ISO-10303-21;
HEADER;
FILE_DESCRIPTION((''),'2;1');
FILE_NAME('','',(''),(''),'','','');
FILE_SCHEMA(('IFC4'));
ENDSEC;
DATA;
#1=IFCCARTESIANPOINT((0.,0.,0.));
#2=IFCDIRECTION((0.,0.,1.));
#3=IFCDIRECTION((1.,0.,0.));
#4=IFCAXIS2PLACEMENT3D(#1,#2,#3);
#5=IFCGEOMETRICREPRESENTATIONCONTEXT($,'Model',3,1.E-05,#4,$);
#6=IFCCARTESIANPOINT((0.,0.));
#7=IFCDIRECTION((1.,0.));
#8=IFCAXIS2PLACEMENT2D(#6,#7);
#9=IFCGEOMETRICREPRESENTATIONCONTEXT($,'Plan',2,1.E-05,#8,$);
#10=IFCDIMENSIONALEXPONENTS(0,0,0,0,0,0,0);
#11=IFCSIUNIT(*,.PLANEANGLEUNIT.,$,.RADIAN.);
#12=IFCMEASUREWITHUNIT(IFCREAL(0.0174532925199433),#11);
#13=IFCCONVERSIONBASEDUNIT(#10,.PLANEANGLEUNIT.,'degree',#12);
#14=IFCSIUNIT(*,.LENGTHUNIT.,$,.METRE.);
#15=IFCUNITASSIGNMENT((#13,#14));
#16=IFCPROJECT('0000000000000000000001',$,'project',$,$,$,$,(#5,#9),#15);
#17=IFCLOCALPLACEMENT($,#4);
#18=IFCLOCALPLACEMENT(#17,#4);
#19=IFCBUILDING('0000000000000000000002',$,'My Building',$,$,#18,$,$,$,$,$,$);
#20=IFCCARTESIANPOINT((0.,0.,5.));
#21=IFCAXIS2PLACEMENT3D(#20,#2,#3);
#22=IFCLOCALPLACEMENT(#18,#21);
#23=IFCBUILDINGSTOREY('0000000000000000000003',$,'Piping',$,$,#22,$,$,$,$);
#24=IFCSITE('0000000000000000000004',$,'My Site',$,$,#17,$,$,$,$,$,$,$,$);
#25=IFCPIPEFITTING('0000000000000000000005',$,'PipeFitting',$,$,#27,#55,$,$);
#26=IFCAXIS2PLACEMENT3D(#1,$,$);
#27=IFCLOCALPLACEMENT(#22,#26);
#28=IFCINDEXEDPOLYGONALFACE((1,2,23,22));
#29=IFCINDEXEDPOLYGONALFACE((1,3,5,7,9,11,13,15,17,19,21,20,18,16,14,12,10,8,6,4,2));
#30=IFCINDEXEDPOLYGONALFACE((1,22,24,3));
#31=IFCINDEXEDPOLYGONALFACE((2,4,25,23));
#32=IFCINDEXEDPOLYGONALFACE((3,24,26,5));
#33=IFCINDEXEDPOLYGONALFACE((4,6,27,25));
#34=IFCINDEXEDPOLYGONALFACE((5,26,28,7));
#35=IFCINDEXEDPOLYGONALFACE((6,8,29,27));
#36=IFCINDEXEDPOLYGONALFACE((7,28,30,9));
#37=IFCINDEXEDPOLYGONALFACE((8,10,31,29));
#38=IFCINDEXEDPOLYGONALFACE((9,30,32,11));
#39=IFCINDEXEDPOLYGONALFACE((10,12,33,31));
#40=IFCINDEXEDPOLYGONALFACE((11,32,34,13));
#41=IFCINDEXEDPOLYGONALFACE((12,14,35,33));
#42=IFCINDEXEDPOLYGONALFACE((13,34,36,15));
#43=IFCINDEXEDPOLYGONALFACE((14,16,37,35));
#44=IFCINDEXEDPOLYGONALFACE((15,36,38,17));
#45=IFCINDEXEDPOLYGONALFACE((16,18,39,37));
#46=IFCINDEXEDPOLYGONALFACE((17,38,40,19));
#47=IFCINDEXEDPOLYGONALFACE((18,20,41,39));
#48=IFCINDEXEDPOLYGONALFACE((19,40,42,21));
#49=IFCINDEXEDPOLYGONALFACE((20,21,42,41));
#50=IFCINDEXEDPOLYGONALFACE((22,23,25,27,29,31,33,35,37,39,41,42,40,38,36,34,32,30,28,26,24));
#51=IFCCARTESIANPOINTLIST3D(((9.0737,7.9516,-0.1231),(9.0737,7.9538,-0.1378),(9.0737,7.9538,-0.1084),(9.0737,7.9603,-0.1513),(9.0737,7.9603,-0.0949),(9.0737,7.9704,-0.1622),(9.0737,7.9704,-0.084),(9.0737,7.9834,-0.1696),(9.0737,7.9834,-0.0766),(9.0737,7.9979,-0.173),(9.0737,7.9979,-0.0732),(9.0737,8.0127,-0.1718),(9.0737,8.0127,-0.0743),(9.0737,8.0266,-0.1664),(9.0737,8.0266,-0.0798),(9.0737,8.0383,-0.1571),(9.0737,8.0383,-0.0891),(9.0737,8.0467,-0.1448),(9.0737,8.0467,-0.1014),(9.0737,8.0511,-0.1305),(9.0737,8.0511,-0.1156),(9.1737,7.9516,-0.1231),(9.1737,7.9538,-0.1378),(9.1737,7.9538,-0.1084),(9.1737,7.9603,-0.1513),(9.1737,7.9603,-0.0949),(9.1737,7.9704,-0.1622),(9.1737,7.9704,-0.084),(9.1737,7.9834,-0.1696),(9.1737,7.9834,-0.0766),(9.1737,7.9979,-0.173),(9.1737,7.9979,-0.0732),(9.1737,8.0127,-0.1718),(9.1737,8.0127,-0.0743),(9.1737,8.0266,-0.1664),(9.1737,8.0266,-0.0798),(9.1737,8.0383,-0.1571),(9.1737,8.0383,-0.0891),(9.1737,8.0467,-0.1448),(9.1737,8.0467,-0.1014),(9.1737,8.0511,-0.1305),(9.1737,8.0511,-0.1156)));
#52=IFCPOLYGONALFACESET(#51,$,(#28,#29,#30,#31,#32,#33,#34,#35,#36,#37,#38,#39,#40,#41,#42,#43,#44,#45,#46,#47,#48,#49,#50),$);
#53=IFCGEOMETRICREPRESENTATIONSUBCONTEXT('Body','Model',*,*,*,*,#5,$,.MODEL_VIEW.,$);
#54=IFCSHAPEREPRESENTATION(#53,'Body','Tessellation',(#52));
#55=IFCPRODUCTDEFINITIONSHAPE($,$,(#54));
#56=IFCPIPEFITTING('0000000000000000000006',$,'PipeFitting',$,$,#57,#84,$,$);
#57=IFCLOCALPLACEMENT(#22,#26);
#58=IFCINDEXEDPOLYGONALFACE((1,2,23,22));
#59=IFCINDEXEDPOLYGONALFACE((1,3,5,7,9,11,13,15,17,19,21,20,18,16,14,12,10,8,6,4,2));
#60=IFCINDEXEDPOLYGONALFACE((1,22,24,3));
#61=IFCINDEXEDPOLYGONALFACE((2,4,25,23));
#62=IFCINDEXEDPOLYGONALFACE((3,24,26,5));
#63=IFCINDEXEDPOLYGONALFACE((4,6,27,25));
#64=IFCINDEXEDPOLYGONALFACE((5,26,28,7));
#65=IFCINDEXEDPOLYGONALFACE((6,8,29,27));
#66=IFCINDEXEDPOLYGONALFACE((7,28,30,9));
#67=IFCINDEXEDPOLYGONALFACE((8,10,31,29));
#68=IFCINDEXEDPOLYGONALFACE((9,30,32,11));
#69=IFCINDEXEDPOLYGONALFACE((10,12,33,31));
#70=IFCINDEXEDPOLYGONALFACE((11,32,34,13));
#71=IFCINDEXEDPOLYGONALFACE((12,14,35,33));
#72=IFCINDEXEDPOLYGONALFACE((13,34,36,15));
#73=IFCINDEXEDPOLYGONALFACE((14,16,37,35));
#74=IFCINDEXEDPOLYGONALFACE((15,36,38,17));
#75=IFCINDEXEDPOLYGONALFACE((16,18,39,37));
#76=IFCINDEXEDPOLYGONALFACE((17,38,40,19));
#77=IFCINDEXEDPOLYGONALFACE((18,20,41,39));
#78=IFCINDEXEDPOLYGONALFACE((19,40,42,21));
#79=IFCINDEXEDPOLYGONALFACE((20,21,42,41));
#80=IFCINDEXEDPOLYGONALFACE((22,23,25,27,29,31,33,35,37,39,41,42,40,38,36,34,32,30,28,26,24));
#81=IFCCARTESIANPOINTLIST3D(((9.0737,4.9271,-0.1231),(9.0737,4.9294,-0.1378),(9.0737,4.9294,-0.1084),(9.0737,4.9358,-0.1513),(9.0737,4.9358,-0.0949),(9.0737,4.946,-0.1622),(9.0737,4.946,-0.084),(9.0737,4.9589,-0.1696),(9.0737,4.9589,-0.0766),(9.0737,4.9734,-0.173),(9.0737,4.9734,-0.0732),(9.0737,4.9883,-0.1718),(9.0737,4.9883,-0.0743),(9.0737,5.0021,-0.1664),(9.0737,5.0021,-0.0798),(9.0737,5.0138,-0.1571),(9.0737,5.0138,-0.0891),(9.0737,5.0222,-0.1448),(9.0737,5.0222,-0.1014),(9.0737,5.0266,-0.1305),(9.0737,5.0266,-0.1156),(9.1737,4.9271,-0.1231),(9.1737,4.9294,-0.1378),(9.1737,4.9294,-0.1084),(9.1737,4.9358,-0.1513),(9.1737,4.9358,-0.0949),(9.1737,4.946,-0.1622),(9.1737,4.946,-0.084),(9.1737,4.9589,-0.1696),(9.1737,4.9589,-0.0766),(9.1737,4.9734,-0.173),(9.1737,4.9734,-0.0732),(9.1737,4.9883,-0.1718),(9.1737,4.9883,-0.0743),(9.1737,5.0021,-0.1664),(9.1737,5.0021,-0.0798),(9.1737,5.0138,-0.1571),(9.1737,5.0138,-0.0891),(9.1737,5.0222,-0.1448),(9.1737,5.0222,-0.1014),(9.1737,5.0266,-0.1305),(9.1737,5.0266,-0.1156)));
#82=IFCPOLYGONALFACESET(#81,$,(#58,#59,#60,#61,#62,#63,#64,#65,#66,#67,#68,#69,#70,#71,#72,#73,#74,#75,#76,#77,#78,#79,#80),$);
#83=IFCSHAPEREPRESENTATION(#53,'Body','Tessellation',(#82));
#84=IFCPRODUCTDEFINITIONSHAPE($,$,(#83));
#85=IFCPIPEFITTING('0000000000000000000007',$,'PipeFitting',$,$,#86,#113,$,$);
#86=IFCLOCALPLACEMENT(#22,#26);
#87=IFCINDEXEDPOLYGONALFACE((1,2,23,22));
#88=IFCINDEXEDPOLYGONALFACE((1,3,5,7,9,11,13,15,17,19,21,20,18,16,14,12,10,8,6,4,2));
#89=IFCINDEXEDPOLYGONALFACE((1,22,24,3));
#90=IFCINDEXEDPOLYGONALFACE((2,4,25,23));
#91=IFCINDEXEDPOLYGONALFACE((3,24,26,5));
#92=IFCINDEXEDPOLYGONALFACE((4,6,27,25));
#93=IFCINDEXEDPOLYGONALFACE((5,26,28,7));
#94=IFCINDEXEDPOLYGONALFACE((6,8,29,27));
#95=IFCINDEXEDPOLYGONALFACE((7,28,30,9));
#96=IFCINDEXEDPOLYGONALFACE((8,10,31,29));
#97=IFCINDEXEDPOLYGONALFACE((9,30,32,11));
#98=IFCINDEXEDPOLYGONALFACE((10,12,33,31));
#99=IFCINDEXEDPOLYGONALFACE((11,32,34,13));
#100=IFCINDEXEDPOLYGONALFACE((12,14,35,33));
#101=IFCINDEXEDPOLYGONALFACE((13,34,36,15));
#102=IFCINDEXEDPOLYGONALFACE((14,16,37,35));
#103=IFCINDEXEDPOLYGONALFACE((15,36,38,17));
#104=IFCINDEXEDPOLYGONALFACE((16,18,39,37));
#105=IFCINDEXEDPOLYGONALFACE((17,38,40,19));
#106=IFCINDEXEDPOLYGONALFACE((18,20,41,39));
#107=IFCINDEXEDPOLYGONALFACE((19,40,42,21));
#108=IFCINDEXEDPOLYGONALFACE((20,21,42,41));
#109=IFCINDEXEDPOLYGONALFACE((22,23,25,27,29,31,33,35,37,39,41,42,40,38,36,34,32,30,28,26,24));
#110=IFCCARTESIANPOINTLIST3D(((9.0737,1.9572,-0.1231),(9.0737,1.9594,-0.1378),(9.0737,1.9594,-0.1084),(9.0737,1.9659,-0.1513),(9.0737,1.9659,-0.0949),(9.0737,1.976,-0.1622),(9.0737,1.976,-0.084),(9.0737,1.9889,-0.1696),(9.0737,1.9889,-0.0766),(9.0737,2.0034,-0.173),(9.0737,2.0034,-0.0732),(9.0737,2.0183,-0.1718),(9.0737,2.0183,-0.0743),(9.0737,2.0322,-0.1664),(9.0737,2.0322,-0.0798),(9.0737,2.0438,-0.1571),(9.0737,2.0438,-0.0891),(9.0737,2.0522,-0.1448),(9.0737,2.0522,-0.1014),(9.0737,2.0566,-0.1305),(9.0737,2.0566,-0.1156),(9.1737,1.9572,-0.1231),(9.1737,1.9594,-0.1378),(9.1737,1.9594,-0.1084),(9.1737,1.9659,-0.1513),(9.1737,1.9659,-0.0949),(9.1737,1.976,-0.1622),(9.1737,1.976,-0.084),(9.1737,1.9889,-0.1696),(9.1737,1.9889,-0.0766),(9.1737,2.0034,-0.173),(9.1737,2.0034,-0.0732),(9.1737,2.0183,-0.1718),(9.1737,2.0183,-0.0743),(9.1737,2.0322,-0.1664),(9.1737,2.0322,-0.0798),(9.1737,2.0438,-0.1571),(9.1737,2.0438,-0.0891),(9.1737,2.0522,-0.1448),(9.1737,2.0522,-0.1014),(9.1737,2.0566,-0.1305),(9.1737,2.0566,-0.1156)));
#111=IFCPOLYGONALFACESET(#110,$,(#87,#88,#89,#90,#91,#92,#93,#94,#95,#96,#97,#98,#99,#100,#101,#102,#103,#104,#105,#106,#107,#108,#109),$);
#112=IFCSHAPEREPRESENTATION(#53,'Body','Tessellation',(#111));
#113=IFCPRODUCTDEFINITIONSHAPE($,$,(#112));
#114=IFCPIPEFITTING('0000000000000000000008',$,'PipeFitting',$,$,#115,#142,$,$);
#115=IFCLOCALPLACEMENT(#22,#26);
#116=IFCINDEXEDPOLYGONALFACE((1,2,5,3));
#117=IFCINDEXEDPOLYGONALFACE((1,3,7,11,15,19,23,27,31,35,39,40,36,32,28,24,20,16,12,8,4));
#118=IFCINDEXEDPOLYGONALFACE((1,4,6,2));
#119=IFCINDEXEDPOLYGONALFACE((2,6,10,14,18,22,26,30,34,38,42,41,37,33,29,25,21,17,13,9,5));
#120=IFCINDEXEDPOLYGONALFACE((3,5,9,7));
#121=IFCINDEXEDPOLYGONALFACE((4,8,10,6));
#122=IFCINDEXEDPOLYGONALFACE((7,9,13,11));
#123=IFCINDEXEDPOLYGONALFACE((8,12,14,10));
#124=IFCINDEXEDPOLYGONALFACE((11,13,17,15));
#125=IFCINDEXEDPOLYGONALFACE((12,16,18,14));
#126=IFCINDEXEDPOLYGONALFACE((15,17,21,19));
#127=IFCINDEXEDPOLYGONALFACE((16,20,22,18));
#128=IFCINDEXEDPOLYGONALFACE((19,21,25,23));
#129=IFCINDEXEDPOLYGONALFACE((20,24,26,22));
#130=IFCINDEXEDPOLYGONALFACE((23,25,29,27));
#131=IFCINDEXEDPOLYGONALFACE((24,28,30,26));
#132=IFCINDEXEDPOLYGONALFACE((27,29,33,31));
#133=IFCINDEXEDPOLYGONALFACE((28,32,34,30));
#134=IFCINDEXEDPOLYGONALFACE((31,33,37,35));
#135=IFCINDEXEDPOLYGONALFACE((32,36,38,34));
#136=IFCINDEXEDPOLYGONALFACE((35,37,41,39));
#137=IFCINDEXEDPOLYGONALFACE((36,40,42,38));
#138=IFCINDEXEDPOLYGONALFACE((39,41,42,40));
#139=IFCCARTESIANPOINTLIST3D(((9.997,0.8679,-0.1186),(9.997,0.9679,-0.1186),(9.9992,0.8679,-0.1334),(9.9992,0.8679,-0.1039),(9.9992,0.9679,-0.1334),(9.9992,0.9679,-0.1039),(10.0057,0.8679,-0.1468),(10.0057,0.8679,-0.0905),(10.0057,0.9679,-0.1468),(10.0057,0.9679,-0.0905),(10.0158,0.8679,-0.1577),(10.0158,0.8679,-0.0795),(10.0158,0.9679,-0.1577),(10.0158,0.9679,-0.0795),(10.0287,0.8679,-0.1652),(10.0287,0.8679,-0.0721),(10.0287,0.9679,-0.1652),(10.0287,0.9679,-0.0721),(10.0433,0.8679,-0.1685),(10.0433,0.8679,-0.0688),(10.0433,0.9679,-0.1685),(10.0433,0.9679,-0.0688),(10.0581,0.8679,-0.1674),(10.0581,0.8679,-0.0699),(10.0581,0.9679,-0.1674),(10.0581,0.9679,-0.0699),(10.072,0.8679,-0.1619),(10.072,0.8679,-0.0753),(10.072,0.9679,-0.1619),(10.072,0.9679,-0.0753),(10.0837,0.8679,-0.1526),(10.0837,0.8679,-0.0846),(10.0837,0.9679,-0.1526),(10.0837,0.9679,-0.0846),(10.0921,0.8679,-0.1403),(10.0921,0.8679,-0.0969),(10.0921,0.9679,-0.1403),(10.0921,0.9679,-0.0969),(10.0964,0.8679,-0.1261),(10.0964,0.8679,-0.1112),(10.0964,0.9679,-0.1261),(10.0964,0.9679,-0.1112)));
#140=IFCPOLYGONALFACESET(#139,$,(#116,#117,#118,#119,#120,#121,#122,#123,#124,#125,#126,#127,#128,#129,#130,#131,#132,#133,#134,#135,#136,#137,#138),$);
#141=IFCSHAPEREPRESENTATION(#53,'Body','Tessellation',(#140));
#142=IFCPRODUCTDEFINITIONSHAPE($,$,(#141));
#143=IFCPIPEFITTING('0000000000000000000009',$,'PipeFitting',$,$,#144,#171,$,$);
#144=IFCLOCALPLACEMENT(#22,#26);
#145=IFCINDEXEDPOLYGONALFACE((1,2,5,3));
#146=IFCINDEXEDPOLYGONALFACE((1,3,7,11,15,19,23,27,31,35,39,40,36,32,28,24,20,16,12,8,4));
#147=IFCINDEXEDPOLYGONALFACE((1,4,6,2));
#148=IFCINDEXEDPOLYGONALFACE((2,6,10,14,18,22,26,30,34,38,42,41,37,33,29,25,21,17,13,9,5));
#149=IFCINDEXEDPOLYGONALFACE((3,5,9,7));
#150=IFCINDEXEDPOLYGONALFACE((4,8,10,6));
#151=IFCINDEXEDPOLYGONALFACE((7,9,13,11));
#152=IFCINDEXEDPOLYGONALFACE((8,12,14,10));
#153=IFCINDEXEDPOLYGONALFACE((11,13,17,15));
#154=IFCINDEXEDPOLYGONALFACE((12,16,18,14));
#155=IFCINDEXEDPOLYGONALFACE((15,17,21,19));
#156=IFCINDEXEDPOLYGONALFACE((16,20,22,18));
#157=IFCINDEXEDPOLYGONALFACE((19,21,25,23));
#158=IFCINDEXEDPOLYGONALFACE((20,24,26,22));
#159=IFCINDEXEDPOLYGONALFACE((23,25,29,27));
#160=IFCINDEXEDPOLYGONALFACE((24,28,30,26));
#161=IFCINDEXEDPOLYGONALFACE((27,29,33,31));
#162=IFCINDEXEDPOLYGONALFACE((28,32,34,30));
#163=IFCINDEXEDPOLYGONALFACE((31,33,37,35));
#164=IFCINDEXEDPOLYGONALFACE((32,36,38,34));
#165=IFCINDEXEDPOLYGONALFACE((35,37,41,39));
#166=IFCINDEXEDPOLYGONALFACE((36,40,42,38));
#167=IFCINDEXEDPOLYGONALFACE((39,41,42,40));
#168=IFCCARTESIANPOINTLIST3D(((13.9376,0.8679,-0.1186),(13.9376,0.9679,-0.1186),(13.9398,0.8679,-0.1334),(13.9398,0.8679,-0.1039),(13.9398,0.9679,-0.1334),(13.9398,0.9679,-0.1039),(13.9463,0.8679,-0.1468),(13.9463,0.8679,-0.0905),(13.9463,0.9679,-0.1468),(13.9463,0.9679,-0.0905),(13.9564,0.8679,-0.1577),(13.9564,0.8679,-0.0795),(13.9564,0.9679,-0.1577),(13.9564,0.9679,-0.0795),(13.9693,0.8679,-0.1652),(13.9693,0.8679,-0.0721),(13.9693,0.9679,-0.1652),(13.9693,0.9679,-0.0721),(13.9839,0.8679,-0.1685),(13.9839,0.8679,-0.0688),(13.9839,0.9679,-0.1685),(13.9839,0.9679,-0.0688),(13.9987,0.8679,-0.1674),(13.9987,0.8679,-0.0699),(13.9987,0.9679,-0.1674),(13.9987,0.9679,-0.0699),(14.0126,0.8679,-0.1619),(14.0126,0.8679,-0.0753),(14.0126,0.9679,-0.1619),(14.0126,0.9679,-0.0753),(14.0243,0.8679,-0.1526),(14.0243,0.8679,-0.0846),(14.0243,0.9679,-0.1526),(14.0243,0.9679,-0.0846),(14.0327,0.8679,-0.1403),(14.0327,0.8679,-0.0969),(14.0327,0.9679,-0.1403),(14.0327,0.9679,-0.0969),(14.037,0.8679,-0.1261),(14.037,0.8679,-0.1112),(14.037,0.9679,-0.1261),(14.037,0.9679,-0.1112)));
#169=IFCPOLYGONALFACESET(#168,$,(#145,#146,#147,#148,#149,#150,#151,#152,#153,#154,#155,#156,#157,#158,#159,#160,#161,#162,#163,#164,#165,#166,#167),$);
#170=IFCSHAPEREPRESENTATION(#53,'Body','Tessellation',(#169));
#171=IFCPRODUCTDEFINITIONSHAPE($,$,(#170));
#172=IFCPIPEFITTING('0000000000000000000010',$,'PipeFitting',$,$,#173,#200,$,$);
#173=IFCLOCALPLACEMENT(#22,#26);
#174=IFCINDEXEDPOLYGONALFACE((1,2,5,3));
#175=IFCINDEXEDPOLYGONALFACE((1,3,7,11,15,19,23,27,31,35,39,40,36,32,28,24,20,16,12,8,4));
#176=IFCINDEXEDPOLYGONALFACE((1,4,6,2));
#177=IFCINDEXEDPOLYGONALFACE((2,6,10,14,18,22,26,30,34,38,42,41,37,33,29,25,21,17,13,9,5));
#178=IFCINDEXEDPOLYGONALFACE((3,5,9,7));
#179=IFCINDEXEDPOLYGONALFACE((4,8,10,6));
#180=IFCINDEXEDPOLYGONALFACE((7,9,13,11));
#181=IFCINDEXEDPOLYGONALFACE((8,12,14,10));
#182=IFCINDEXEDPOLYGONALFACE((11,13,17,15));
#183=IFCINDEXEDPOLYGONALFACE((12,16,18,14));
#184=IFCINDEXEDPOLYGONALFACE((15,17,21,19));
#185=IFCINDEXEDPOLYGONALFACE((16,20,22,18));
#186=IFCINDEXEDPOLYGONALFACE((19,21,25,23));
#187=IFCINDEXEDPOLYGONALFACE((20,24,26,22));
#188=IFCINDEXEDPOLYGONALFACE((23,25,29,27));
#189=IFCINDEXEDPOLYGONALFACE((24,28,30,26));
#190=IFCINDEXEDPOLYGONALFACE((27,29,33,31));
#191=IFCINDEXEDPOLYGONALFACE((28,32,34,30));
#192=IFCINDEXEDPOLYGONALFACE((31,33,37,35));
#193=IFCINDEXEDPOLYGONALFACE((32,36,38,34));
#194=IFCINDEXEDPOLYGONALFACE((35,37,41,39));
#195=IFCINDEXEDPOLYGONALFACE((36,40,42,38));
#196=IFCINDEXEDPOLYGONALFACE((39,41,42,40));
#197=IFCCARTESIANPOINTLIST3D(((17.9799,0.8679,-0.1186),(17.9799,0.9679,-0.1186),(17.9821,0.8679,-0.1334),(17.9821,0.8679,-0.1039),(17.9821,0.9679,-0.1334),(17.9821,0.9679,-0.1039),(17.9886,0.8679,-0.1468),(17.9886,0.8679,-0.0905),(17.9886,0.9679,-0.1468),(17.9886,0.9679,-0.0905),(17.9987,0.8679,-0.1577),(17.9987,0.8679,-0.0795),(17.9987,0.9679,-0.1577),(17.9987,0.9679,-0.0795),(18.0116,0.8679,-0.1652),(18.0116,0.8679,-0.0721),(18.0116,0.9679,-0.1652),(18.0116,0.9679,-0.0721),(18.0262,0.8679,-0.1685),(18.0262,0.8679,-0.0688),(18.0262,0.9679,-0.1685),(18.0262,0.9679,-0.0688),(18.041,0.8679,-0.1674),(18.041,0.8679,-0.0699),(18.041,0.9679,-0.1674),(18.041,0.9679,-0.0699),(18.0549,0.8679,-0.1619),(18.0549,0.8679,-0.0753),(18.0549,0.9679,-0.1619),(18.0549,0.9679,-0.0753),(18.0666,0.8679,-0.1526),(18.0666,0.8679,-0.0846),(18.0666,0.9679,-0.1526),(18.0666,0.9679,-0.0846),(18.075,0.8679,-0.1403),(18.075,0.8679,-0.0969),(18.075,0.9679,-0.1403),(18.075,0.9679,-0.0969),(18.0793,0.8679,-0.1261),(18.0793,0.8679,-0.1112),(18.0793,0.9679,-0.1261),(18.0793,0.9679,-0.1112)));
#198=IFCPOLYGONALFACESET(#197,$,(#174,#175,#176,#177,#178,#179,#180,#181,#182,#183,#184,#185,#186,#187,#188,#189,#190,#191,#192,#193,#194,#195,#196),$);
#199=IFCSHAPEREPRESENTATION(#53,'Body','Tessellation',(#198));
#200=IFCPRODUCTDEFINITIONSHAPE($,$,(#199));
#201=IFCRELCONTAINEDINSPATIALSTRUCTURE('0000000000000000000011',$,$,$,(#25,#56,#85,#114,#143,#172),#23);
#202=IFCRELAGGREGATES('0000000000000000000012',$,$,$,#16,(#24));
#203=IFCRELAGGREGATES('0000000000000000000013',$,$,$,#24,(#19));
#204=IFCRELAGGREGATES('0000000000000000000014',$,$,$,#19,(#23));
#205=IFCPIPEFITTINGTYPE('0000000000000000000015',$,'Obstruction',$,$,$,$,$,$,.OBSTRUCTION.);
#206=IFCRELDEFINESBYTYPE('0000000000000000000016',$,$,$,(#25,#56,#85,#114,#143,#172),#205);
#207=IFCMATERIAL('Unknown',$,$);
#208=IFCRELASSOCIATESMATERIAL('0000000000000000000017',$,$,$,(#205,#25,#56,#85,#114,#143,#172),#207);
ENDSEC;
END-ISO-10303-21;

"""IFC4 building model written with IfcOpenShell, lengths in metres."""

from ifc_helpers import new_model, entity, si_unit, converted_unit, frame, origin_with_axes, origin_2d_with_axis, place, context, subcontext, project, spatial, circle, extrude, material, material_profile, profile_set, profile_usage, type_object, element, save


model = new_model("IFC4")

# Units and contexts
model_context = context("Model", 3, precision=1e-05, world=origin_with_axes())
plan_context = context("Plan", 2, precision=1e-05, world=origin_2d_with_axis())
body_context = subcontext(model_context, "Body", "Model", "MODEL_VIEW")
ifc_project = project(units=[converted_unit("PLANEANGLEUNIT", "degree", entity("IfcReal", 0.0174532925199433), si_unit("PLANEANGLEUNIT", "RADIAN"), dimensions=[0, 0, 0, 0, 0, 0, 0]), si_unit("LENGTHUNIT", "METRE")], contexts=[model_context, plan_context])

# Site, building, storey
site_placement = place(None, origin_with_axes())
site = spatial("IfcSite", under=ifc_project, at=site_placement, Name="My Site")
building_placement = place(site_placement, origin_with_axes())
building = spatial("IfcBuilding", under=site, at=building_placement, Name="My Building")
storey_placement = place(building_placement, frame((0.0, 0.0, 5.0), z_axis=(0.0, 0.0, 1.0), x_axis=(1.0, 0.0, 0.0)))
storey = spatial("IfcBuildingStorey", under=building, at=storey_placement, Name="Piping")

# Shared definitions
ifc_material = material(Name="Unknown")

# Pipe fittings
ifc_material_profile_1 = material_profile(ifc_material, circle(Radius=0.05))
ifc_profile_set_1 = profile_set([ifc_material_profile_1])
ifc_profile_usage_1 = profile_usage(ifc_profile_set_1, cardinal=5)
pipe_fitting_type_1 = type_object("IfcPipeFittingType", Name="Obstruction", PredefinedType="OBSTRUCTION", material=ifc_profile_set_1)
pipe_fitting_1_placement = place(storey_placement, frame((9.1737, 8.0016, -0.1231), z_axis=(-1.0, 0.0, 0.0), x_axis=(0.0, -1.0, 0.0)))
element("IfcPipeFitting", 1, at=pipe_fitting_1_placement, inside=storey, type_object=pipe_fitting_type_1, material=ifc_profile_usage_1, Name="PipeFitting", context=body_context, shape_type="SweptSolid", body=[
    extrude(circle(Radius=0.05), origin_with_axes(), (0.0, 0.0, 1.0), 0.1),
])
ifc_profile_usage_2 = profile_usage(ifc_profile_set_1, cardinal=5)
pipe_fitting_2_placement = place(storey_placement, frame((9.1737, 4.9771, -0.1231), z_axis=(-1.0, 0.0, 0.0), x_axis=(0.0, -1.0, 0.0)))
element("IfcPipeFitting", 2, at=pipe_fitting_2_placement, inside=storey, type_object=pipe_fitting_type_1, material=ifc_profile_usage_2, Name="PipeFitting", context=body_context, shape_type="SweptSolid", body=[
    extrude(circle(Radius=0.05), origin_with_axes(), (0.0, 0.0, 1.0), 0.1),
])
ifc_profile_usage_3 = profile_usage(ifc_profile_set_1, cardinal=5)
pipe_fitting_3_placement = place(storey_placement, frame((9.1737, 2.0072, -0.1231), z_axis=(-1.0, 0.0, 0.0), x_axis=(0.0, -1.0, 0.0)))
element("IfcPipeFitting", 3, at=pipe_fitting_3_placement, inside=storey, type_object=pipe_fitting_type_1, material=ifc_profile_usage_3, Name="PipeFitting", context=body_context, shape_type="SweptSolid", body=[
    extrude(circle(Radius=0.05), origin_with_axes(), (0.0, 0.0, 1.0), 0.1),
])
ifc_profile_usage_4 = profile_usage(ifc_profile_set_1, cardinal=5)
pipe_fitting_4_placement = place(storey_placement, frame((10.047, 0.8679, -0.1186), z_axis=(0.0, 1.0, 0.0), x_axis=(-1.0, 0.0, 0.0)))
element("IfcPipeFitting", 4, at=pipe_fitting_4_placement, inside=storey, type_object=pipe_fitting_type_1, material=ifc_profile_usage_4, Name="PipeFitting", context=body_context, shape_type="SweptSolid", body=[
    extrude(circle(Radius=0.05), origin_with_axes(), (0.0, 0.0, 1.0), 0.1),
])
ifc_profile_usage_5 = profile_usage(ifc_profile_set_1, cardinal=5)
pipe_fitting_5_placement = place(storey_placement, frame((13.9876, 0.8679, -0.1186), z_axis=(0.0, 1.0, 0.0), x_axis=(-1.0, 0.0, 0.0)))
element("IfcPipeFitting", 5, at=pipe_fitting_5_placement, inside=storey, type_object=pipe_fitting_type_1, material=ifc_profile_usage_5, Name="PipeFitting", context=body_context, shape_type="SweptSolid", body=[
    extrude(circle(Radius=0.05), origin_with_axes(), (0.0, 0.0, 1.0), 0.1),
])
ifc_profile_usage_6 = profile_usage(ifc_profile_set_1, cardinal=5)
pipe_fitting_6_placement = place(storey_placement, frame((18.0299, 0.8679, -0.1186), z_axis=(0.0, 1.0, 0.0), x_axis=(-1.0, 0.0, 0.0)))
element("IfcPipeFitting", 6, at=pipe_fitting_6_placement, inside=storey, type_object=pipe_fitting_type_1, material=ifc_profile_usage_6, Name="PipeFitting", context=body_context, shape_type="SweptSolid", body=[
    extrude(circle(Radius=0.05), origin_with_axes(), (0.0, 0.0, 1.0), 0.1),
])

save(model, "model.ifc")
